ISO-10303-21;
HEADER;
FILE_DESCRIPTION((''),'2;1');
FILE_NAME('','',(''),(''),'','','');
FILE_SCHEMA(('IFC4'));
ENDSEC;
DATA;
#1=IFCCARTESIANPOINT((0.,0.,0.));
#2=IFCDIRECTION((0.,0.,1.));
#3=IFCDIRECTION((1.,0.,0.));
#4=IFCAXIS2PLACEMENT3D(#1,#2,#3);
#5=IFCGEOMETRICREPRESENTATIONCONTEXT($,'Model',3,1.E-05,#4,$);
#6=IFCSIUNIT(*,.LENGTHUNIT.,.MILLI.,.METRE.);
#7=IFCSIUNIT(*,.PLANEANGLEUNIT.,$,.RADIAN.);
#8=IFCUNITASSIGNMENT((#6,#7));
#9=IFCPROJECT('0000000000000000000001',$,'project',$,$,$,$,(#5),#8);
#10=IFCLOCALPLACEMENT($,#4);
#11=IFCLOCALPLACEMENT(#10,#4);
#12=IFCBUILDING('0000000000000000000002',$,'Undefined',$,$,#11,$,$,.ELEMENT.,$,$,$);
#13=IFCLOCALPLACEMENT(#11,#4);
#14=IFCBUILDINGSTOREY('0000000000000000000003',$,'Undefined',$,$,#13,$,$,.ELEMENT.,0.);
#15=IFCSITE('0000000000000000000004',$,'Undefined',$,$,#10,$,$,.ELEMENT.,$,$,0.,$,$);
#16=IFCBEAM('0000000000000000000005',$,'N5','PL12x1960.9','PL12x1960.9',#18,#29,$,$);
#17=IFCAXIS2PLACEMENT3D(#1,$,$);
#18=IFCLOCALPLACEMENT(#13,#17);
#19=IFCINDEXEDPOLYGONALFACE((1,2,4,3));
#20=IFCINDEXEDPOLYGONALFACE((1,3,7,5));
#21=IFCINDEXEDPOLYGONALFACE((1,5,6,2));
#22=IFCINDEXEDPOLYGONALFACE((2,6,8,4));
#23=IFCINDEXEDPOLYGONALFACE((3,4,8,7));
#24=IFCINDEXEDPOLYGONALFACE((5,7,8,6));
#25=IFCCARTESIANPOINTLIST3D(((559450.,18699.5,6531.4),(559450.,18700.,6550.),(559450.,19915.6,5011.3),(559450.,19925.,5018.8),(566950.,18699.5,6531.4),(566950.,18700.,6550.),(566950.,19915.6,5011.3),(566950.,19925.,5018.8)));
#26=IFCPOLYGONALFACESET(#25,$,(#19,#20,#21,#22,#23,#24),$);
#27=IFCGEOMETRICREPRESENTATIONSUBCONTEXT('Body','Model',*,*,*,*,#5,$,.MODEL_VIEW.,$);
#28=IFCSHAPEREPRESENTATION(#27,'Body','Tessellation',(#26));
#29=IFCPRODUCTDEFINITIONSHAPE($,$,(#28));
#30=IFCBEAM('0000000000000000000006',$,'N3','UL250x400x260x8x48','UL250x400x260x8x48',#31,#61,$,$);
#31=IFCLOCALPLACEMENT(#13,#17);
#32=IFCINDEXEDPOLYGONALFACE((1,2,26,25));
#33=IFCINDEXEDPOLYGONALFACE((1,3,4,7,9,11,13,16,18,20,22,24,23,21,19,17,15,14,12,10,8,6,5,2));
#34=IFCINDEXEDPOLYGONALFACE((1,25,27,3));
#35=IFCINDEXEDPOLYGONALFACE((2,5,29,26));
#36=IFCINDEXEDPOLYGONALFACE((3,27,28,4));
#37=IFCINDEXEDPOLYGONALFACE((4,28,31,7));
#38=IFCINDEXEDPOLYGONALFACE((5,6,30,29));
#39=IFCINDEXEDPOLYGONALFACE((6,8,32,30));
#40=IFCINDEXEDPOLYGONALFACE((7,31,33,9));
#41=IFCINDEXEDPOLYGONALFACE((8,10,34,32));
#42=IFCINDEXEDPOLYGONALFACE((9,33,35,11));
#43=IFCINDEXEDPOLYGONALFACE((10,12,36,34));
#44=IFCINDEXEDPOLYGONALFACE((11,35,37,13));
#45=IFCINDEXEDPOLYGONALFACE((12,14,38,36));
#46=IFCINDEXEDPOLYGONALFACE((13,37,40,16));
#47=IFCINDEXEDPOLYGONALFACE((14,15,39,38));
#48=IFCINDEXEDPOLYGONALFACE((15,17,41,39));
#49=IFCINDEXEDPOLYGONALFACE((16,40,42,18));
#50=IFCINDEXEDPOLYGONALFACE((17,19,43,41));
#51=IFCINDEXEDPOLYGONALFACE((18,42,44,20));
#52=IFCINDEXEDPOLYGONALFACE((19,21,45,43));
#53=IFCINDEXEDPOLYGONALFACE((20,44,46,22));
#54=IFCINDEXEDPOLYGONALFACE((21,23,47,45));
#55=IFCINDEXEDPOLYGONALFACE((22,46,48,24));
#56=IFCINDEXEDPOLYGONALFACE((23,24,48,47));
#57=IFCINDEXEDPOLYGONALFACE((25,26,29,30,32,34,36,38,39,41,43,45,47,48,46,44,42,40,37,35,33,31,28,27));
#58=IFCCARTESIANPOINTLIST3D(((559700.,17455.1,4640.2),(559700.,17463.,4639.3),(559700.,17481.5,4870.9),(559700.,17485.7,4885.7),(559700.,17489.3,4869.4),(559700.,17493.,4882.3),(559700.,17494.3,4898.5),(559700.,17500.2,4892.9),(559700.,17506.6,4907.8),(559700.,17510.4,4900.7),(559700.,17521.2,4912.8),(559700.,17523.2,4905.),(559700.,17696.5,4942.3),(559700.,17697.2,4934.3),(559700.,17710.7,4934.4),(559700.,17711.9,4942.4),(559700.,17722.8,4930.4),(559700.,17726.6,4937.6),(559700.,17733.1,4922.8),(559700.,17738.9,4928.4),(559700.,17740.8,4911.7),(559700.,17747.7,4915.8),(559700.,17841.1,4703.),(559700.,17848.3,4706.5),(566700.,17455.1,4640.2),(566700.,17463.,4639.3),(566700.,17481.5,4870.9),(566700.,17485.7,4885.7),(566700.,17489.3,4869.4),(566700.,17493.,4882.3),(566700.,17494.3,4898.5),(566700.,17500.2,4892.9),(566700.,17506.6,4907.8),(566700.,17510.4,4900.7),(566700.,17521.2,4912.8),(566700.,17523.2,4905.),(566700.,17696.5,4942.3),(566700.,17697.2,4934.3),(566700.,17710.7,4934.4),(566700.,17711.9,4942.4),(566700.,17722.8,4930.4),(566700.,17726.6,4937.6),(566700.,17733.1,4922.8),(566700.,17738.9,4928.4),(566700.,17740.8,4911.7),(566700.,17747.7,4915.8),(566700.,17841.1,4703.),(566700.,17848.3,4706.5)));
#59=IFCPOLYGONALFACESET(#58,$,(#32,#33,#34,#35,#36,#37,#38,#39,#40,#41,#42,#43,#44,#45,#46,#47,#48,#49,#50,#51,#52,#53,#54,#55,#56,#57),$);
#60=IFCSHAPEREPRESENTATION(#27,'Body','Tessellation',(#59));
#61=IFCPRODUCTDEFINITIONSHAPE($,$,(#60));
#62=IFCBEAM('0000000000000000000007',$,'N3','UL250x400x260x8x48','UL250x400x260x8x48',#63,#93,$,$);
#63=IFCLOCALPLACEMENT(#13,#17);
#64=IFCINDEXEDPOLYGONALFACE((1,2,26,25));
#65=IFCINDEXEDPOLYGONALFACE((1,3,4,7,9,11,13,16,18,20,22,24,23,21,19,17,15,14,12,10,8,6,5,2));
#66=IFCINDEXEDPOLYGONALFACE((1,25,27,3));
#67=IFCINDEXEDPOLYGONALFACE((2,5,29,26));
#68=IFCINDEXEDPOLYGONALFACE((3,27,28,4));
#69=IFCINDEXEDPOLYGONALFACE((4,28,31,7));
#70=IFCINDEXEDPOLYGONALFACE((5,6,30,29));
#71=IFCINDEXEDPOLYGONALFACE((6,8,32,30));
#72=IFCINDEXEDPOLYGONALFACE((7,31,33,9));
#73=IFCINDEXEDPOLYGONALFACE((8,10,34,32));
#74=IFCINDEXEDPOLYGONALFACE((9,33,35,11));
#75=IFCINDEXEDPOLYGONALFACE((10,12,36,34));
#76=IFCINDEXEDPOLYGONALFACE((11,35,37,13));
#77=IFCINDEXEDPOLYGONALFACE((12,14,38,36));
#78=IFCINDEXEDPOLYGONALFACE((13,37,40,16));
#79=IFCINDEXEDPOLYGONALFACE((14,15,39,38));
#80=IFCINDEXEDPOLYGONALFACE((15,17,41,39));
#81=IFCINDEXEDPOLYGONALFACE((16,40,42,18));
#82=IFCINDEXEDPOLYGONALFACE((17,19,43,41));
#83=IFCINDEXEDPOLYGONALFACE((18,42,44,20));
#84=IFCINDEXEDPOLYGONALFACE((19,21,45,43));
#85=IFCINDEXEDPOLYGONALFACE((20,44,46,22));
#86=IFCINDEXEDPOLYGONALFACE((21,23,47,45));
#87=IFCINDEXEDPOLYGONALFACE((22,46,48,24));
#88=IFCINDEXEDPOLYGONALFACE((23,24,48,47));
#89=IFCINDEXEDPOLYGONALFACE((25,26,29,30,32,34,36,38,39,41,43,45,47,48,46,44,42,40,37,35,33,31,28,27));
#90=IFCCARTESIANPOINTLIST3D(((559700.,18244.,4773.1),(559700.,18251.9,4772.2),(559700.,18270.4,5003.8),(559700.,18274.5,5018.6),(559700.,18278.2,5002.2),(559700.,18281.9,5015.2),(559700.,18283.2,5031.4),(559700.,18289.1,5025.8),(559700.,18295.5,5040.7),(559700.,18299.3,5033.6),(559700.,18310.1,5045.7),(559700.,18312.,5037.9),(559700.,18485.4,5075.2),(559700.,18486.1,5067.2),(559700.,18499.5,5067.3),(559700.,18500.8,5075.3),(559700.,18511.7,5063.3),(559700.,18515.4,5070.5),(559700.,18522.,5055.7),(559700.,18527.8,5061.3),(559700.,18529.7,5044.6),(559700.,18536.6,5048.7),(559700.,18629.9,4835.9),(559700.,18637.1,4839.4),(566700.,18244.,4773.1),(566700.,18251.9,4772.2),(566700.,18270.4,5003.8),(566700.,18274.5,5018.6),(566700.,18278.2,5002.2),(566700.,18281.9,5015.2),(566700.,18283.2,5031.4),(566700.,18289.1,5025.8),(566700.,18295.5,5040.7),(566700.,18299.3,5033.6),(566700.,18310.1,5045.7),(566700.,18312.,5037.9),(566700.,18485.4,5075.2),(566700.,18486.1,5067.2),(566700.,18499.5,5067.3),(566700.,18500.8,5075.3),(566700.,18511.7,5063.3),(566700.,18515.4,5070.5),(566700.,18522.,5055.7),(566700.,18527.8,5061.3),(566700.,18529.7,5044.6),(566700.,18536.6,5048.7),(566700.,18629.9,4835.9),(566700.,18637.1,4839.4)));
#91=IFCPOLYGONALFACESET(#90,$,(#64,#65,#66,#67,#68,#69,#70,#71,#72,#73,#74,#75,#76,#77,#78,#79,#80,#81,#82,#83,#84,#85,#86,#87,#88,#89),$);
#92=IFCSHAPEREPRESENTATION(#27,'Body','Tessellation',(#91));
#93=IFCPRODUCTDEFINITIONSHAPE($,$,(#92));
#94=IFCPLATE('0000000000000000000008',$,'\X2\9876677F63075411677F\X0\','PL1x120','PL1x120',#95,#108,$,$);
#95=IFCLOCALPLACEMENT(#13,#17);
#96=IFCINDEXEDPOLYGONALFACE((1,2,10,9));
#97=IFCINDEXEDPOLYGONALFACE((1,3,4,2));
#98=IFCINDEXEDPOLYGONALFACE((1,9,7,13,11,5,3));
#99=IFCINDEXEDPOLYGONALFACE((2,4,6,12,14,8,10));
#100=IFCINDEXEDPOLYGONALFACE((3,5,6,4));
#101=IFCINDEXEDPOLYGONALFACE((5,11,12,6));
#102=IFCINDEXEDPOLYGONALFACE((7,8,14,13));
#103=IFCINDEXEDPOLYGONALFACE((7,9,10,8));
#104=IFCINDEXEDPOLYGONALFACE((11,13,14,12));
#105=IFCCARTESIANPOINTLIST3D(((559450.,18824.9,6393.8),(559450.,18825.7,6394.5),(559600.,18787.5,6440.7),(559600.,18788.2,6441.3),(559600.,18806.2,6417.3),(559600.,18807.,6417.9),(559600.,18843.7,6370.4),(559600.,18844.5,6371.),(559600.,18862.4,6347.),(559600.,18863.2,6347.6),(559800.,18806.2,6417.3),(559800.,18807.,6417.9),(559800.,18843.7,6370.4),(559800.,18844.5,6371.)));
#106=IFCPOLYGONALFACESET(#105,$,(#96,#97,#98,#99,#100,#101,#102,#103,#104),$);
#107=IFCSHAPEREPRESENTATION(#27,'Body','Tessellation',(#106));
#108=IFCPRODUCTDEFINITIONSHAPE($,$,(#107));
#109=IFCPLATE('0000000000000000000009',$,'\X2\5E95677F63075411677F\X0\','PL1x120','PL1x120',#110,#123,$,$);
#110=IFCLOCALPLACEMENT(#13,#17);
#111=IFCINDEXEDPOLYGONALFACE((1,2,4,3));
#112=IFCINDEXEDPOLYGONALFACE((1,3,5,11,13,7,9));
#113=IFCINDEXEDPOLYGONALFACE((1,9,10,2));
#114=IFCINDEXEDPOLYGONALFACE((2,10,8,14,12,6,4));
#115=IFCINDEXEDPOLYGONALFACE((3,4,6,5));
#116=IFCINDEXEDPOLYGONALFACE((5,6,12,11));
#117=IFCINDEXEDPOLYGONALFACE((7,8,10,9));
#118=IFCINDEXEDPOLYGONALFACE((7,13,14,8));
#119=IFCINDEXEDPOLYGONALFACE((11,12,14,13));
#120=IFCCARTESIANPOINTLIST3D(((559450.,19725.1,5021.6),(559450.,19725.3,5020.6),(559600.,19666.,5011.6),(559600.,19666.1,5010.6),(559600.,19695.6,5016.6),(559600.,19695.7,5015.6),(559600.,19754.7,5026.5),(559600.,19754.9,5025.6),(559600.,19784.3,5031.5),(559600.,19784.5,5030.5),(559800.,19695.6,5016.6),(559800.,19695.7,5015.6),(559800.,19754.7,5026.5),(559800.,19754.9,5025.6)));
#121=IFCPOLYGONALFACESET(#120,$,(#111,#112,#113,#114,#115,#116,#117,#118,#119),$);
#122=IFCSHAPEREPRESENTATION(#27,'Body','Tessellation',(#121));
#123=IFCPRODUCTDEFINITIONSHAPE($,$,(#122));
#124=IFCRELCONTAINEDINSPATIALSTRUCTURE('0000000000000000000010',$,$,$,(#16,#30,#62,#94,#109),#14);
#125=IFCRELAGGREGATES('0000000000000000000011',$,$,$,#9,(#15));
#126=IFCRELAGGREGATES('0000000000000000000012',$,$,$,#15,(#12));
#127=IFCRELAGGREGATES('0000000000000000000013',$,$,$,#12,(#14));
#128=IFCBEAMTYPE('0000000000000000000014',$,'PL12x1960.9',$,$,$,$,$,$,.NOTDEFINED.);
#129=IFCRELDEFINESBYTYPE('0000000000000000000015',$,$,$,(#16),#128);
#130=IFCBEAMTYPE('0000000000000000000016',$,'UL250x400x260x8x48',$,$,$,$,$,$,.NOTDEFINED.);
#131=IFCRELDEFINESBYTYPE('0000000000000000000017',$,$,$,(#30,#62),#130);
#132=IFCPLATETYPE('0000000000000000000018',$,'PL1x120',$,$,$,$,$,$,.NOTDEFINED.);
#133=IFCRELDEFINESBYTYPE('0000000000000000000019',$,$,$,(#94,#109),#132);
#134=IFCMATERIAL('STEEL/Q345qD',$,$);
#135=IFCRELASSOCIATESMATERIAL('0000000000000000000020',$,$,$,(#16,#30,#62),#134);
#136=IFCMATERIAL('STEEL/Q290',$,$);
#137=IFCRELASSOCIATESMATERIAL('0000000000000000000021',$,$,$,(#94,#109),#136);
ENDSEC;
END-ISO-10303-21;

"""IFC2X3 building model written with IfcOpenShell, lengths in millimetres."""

from ifc_helpers import new_model, si_unit, frame, origin_with_axes, origin_2d_with_axis, place, context, subcontext, project, spatial, polyline, rectangle, outline, extrude, clip, halfspace, material, type_object, element, save


model = new_model("IFC2X3")

# Units and contexts
model_context = context("Model", 3, precision=1e-05, world=origin_with_axes())
body_context = subcontext(model_context, "Body", "Model", "MODEL_VIEW")
ifc_project = project(units=[si_unit("LENGTHUNIT", "METRE", prefix="MILLI"), si_unit("PLANEANGLEUNIT", "RADIAN")], contexts=[model_context])

# Site, building, storey
site_placement = place(None, origin_with_axes())
site = spatial("IfcSite", under=ifc_project, at=site_placement, Name="Undefined", CompositionType="ELEMENT", RefElevation=0.0)
building_placement = place(site_placement, origin_with_axes())
building = spatial("IfcBuilding", under=site, at=building_placement, Name="Undefined", CompositionType="ELEMENT")
storey_placement = place(building_placement, origin_with_axes())
storey = spatial("IfcBuildingStorey", under=building, at=storey_placement, Name="Undefined", CompositionType="ELEMENT", Elevation=0.0)

# Beams
ifc_material_1 = material(Name="STEEL/Q345qD")
beam_type_1 = type_object("IfcBeamType", Name="PL12x1960.9", PredefinedType="NOTDEFINED")
beam_placement = place(storey_placement, frame((566950.0, 19307.8, 5780.6), z_axis=(0.0, 0.624695, -0.780869), x_axis=(-1.0, 0.0, 0.0)))
element("IfcBeam", 1, at=beam_placement, inside=storey, type_object=beam_type_1, material=ifc_material_1, Name="N5", Description="PL12x1960.9", ObjectType="PL12x1960.9", context=body_context, shape_type="Clipping", body=[
    clip(extrude(rectangle(XDim=12.0, YDim=1960.9, at=origin_2d_with_axis()), frame((7500.0, 0.0, 0.0), z_axis=(-1.0, 0.0, 0.0), x_axis=(0.0, -1.0, 0.0)), (0.0, 0.0, 1.0), 7500.0), halfspace(frame((7500.0, 6.0, -980.5), z_axis=(0.0, -0.765312, -0.64366), x_axis=(-1.0, 0.0, 0.0)), False)),
])
beam_type_2 = type_object("IfcBeamType", Name="UL250x400x260x8x48", PredefinedType="NOTDEFINED")
for number, where, z_axis, x_axis, name in (
    (2, (559700.0, 17630.4, 4799.4), (0.0, -0.166152, 0.9861), (1.0, 0.0, 0.0), "N3"),
    (3, (559700.0, 18419.3, 4932.3), (0.0, -0.166152, 0.9861), (1.0, 0.0, 0.0), "N3"),
):
    element("IfcBeam", number, at=place(storey_placement, frame(where, z_axis=z_axis, x_axis=x_axis)), inside=storey, type_object=beam_type_2, material=ifc_material_1, Name=name, Description="UL250x400x260x8x48", ObjectType="UL250x400x260x8x48", context=body_context, shape_type="SweptSolid", body=[
        extrude(outline(polyline([(199.4, -127.8), (135.0, 95.3), (128.4, 109.2), (117.7, 120.4), (104.1, 127.5), (88.9, 130.0), (-88.9, 130.0), (-104.1, 127.5), (-117.7, 120.4), (-128.4, 109.2), (-135.0, 95.3), (-199.4, -127.8), (-191.7, -130.0), (-127.5, 92.5), (-121.7, 104.6), (-112.9, 113.9), (-101.5, 119.8), (-88.2, 122.0), (88.2, 122.0), (101.5, 119.8), (112.9, 113.9), (121.7, 104.6), (127.5, 92.5), (191.7, -130.0), (199.4, -127.8)])), frame((7000.0, 0.0, 0.0), z_axis=(-1.0, 0.0, 0.0), x_axis=(0.0, -1.0, 0.0)), (0.0, 0.0, 1.0), 7000.0),
    ])

# Plates
ifc_material_2 = material(Name="STEEL/Q290")
plate_type = type_object("IfcPlateType", Name="PL1x120", PredefinedType="NOTDEFINED")
for number, where, z_axis, x_axis, name in (
    (4, (559800.0, 18806.6, 6417.6), (0.0, 0.780869, 0.624695), (0.0, 0.624695, -0.780869), "顶板指向板"),
    (5, (559800.0, 19754.8, 5026.0), (0.0, 0.166137, -0.986103), (0.0, -0.986103, -0.166137), "底板指向板"),
):
    element("IfcPlate", number, at=place(storey_placement, frame(where, z_axis=z_axis, x_axis=x_axis)), inside=storey, type_object=plate_type, material=ifc_material_2, Name=name, Description="PL1x120", ObjectType="PL1x120", context=body_context, shape_type="SweptSolid", body=[
        extrude(outline(polyline([(0.0, 0.0), (60.0, 0.0), (60.0, 200.0), (90.0, 200.0), (30.0, 350.0), (-30.0, 200.0), (0.0, 200.0), (0.0, 0.0)])), frame((0.0, 0.0, -0.5), z_axis=(0.0, 0.0, 1.0), x_axis=(1.0, 0.0, 0.0)), (0.0, 0.0, 1.0), 1.0),
    ])

save(model, "model.ifc")
